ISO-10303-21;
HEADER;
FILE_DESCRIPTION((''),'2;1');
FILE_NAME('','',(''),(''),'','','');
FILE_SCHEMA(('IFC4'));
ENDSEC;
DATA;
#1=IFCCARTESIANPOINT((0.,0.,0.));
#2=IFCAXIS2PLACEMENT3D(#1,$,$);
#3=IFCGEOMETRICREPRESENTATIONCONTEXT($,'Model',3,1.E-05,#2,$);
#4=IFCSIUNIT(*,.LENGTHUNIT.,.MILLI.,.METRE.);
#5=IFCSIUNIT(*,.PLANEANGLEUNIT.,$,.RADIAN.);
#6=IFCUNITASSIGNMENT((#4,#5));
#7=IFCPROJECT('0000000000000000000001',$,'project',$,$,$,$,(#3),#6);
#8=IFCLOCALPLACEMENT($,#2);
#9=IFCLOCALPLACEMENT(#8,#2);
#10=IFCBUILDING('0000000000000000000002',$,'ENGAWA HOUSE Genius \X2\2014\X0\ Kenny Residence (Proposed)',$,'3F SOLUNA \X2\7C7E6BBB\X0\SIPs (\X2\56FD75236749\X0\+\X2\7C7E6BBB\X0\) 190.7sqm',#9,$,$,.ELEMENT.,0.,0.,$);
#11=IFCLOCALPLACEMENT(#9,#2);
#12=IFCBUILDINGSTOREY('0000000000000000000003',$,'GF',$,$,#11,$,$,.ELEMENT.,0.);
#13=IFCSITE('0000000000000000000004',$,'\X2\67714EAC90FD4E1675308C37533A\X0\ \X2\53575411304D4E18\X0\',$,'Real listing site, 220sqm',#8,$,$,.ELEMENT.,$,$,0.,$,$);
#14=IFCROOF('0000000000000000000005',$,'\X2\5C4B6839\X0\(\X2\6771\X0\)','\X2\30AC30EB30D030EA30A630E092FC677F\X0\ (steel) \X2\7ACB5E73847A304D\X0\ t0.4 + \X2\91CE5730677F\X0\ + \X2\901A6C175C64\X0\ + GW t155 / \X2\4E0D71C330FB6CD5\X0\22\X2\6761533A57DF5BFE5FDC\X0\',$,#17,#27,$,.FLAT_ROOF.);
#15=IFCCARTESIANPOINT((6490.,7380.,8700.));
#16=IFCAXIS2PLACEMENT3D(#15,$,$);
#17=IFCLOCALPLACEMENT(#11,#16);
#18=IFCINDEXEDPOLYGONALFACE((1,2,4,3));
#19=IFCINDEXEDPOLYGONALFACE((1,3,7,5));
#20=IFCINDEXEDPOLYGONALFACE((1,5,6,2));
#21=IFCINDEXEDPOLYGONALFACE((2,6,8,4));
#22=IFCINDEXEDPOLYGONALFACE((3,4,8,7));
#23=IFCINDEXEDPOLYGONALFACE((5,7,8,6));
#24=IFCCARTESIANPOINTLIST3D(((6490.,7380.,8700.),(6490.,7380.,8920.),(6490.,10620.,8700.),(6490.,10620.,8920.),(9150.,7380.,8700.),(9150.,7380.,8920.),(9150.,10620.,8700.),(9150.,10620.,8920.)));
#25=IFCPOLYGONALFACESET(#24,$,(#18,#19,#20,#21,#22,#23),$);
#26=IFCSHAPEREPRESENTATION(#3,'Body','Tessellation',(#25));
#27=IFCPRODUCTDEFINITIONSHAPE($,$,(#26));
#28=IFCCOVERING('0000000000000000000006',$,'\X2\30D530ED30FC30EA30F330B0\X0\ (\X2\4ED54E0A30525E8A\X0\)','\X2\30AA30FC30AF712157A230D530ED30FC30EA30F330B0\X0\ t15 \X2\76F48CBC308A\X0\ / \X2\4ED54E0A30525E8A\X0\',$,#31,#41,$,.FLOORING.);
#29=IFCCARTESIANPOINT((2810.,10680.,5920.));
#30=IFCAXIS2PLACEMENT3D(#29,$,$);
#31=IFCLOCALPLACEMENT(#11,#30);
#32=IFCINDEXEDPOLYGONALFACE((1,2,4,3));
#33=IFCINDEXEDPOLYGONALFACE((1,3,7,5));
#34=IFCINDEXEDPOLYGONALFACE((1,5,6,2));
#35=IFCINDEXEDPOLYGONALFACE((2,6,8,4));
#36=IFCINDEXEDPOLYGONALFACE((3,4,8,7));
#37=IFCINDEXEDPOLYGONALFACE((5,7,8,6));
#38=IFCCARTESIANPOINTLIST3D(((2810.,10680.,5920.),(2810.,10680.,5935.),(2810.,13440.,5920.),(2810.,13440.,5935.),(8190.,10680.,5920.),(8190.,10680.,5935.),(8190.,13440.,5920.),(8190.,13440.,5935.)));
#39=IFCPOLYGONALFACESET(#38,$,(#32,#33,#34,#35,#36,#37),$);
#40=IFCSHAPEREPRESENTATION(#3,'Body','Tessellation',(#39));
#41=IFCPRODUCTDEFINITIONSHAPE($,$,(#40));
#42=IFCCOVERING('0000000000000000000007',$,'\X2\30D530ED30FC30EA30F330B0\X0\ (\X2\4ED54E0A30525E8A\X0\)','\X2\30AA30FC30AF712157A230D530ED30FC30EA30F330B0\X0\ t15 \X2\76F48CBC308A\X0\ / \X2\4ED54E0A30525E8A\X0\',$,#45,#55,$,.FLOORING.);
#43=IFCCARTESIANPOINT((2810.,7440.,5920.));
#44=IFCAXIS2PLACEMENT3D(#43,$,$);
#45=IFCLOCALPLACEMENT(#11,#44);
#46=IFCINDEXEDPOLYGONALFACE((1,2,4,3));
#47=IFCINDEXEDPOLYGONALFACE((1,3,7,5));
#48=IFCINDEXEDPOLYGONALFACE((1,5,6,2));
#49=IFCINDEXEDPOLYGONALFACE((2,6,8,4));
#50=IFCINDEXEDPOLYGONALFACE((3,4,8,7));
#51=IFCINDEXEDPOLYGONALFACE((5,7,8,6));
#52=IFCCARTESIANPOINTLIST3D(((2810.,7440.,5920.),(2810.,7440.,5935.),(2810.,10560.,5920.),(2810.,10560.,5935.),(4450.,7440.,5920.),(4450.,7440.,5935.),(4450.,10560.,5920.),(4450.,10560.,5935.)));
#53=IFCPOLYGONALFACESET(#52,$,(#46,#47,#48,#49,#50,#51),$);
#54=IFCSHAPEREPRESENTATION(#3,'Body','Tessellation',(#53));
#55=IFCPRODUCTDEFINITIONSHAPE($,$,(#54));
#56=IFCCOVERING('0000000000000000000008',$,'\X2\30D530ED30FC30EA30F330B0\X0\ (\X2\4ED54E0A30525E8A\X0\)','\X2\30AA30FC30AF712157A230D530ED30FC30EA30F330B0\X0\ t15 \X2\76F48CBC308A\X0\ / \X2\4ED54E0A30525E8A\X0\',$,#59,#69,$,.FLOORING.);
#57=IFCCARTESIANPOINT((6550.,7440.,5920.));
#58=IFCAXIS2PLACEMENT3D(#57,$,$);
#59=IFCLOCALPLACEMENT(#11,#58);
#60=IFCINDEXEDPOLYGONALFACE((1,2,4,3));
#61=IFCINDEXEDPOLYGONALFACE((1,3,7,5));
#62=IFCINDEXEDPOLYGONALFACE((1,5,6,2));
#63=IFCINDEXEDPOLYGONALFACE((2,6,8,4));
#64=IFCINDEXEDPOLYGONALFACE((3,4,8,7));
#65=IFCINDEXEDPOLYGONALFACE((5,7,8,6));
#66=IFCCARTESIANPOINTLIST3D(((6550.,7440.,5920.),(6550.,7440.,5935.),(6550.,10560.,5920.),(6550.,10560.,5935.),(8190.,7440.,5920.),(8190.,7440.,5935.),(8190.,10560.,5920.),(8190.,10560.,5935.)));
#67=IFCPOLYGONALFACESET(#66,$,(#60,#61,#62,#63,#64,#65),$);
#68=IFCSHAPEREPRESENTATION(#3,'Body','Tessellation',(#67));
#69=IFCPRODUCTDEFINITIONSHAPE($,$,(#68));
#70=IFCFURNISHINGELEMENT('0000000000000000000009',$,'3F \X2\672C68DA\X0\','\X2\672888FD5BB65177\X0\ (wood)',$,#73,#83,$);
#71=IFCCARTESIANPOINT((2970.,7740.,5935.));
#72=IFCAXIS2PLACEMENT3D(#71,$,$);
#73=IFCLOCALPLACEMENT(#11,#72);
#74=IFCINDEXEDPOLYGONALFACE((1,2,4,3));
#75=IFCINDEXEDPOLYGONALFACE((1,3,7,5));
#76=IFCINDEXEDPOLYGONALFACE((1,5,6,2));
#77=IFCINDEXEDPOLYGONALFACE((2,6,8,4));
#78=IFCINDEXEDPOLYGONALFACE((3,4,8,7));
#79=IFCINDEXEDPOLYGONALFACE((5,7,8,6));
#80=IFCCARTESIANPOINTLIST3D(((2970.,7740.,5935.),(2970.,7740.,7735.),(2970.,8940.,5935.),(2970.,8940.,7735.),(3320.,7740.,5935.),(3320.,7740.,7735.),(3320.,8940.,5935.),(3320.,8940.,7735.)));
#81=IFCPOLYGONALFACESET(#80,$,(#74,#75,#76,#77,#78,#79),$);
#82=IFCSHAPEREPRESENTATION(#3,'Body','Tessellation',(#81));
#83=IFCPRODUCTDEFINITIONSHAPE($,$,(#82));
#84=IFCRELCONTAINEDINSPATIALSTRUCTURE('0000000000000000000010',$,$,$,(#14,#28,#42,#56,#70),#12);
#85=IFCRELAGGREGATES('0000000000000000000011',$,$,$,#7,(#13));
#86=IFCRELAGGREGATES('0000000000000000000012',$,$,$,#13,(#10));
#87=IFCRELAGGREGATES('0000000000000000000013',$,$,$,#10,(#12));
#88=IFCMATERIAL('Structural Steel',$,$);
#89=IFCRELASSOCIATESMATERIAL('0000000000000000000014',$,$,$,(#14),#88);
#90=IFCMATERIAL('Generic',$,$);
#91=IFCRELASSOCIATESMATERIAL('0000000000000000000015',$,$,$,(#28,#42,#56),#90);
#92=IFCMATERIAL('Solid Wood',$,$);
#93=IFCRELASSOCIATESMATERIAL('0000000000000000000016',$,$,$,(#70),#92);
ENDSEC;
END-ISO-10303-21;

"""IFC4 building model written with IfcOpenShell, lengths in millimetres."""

from ifc_helpers import new_model, si_unit, frame, frame_2d, origin, place, context, project, spatial, rectangle, extrude, material, element, save


model = new_model("IFC4")

# Units and contexts
model_context = context("Model", 3, precision=1e-05, world=origin())
ifc_project = project(units=[si_unit("LENGTHUNIT", "METRE", prefix="MILLI"), si_unit("PLANEANGLEUNIT", "RADIAN")], contexts=[model_context])

# Site, building, storey
site_placement = place(None, origin())
site = spatial("IfcSite", under=ifc_project, at=site_placement, Name="東京都世田谷区 南向き丘", ObjectType="Real listing site, 220sqm", CompositionType="ELEMENT", RefElevation=0.0)
building_placement = place(site_placement, origin())
building = spatial("IfcBuilding", under=site, at=building_placement, Name="ENGAWA HOUSE Genius — Kenny Residence (Proposed)", ObjectType="3F SOLUNA 籾殻SIPs (国産杉+籾殻) 190.7sqm", CompositionType="ELEMENT", ElevationOfRefHeight=0.0, ElevationOfTerrain=0.0)
storey_placement = place(building_placement, origin())
storey = spatial("IfcBuildingStorey", under=building, at=storey_placement, Name="GF", CompositionType="ELEMENT", Elevation=0.0)

# Shared definitions
ifc_material_1 = material(Name="Solid Wood")

# Shared definitions
ifc_material_2 = material(Name="Generic")

# Roof
ifc_material_3 = material(Name="Structural Steel")
roof_1_placement = place(storey_placement, frame((6490.0, 7380.0, 8700.0)))
element("IfcRoof", 1, at=roof_1_placement, inside=storey, material=ifc_material_3, Name="屋根(東)", Description="ガルバリウム鋼板 (steel) 立平葺き t0.4 + 野地板 + 通気層 + GW t155 / 不燃・法22条区域対応", PredefinedType="FLAT_ROOF", context=model_context, shape_type="SweptSolid", body=[
    extrude(rectangle(XDim=2660.0, YDim=3240.0, at=frame_2d((1330.0, 1620.0))), frame((6490.0, 7380.0, 8700.0)), (0.0, 0.0, 1.0), 220.0),
])

# Coverings
covering_1_placement = place(storey_placement, frame((2810.0, 10680.0, 5920.0)))
element("IfcCovering", 2, at=covering_1_placement, inside=storey, material=ifc_material_2, Name="フローリング (仕上げ床)", Description="オーク無垢フローリング t15 直貼り / 仕上げ床", PredefinedType="FLOORING", context=model_context, shape_type="SweptSolid", body=[
    extrude(rectangle(XDim=5380.0, YDim=2760.0, at=frame_2d((2690.0, 1380.0))), frame((2810.0, 10680.0, 5920.0)), (0.0, 0.0, 1.0), 15.0),
])
covering_2_placement = place(storey_placement, frame((2810.0, 7440.0, 5920.0)))
element("IfcCovering", 3, at=covering_2_placement, inside=storey, material=ifc_material_2, Name="フローリング (仕上げ床)", Description="オーク無垢フローリング t15 直貼り / 仕上げ床", PredefinedType="FLOORING", context=model_context, shape_type="SweptSolid", body=[
    extrude(rectangle(XDim=1640.0, YDim=3120.0, at=frame_2d((820.0, 1560.0))), frame((2810.0, 7440.0, 5920.0)), (0.0, 0.0, 1.0), 15.0),
])
covering_3_placement = place(storey_placement, frame((6550.0, 7440.0, 5920.0)))
element("IfcCovering", 4, at=covering_3_placement, inside=storey, material=ifc_material_2, Name="フローリング (仕上げ床)", Description="オーク無垢フローリング t15 直貼り / 仕上げ床", PredefinedType="FLOORING", context=model_context, shape_type="SweptSolid", body=[
    extrude(rectangle(XDim=1640.0, YDim=3120.0, at=frame_2d((820.0, 1560.0))), frame((6550.0, 7440.0, 5920.0)), (0.0, 0.0, 1.0), 15.0),
])

# Furnishing element
furnishing_placement = place(storey_placement, frame((2970.0, 7740.0, 5935.0)))
element("IfcFurnishingElement", 5, at=furnishing_placement, inside=storey, material=ifc_material_1, Name="3F 本棚", Description="木製家具 (wood)", context=model_context, shape_type="SweptSolid", body=[
    extrude(rectangle(XDim=350.0, YDim=1200.0, at=frame_2d((175.0, 600.0))), frame((2970.0, 7740.0, 5935.0)), (0.0, 0.0, 1.0), 1800.0),
])

save(model, "model.ifc")
